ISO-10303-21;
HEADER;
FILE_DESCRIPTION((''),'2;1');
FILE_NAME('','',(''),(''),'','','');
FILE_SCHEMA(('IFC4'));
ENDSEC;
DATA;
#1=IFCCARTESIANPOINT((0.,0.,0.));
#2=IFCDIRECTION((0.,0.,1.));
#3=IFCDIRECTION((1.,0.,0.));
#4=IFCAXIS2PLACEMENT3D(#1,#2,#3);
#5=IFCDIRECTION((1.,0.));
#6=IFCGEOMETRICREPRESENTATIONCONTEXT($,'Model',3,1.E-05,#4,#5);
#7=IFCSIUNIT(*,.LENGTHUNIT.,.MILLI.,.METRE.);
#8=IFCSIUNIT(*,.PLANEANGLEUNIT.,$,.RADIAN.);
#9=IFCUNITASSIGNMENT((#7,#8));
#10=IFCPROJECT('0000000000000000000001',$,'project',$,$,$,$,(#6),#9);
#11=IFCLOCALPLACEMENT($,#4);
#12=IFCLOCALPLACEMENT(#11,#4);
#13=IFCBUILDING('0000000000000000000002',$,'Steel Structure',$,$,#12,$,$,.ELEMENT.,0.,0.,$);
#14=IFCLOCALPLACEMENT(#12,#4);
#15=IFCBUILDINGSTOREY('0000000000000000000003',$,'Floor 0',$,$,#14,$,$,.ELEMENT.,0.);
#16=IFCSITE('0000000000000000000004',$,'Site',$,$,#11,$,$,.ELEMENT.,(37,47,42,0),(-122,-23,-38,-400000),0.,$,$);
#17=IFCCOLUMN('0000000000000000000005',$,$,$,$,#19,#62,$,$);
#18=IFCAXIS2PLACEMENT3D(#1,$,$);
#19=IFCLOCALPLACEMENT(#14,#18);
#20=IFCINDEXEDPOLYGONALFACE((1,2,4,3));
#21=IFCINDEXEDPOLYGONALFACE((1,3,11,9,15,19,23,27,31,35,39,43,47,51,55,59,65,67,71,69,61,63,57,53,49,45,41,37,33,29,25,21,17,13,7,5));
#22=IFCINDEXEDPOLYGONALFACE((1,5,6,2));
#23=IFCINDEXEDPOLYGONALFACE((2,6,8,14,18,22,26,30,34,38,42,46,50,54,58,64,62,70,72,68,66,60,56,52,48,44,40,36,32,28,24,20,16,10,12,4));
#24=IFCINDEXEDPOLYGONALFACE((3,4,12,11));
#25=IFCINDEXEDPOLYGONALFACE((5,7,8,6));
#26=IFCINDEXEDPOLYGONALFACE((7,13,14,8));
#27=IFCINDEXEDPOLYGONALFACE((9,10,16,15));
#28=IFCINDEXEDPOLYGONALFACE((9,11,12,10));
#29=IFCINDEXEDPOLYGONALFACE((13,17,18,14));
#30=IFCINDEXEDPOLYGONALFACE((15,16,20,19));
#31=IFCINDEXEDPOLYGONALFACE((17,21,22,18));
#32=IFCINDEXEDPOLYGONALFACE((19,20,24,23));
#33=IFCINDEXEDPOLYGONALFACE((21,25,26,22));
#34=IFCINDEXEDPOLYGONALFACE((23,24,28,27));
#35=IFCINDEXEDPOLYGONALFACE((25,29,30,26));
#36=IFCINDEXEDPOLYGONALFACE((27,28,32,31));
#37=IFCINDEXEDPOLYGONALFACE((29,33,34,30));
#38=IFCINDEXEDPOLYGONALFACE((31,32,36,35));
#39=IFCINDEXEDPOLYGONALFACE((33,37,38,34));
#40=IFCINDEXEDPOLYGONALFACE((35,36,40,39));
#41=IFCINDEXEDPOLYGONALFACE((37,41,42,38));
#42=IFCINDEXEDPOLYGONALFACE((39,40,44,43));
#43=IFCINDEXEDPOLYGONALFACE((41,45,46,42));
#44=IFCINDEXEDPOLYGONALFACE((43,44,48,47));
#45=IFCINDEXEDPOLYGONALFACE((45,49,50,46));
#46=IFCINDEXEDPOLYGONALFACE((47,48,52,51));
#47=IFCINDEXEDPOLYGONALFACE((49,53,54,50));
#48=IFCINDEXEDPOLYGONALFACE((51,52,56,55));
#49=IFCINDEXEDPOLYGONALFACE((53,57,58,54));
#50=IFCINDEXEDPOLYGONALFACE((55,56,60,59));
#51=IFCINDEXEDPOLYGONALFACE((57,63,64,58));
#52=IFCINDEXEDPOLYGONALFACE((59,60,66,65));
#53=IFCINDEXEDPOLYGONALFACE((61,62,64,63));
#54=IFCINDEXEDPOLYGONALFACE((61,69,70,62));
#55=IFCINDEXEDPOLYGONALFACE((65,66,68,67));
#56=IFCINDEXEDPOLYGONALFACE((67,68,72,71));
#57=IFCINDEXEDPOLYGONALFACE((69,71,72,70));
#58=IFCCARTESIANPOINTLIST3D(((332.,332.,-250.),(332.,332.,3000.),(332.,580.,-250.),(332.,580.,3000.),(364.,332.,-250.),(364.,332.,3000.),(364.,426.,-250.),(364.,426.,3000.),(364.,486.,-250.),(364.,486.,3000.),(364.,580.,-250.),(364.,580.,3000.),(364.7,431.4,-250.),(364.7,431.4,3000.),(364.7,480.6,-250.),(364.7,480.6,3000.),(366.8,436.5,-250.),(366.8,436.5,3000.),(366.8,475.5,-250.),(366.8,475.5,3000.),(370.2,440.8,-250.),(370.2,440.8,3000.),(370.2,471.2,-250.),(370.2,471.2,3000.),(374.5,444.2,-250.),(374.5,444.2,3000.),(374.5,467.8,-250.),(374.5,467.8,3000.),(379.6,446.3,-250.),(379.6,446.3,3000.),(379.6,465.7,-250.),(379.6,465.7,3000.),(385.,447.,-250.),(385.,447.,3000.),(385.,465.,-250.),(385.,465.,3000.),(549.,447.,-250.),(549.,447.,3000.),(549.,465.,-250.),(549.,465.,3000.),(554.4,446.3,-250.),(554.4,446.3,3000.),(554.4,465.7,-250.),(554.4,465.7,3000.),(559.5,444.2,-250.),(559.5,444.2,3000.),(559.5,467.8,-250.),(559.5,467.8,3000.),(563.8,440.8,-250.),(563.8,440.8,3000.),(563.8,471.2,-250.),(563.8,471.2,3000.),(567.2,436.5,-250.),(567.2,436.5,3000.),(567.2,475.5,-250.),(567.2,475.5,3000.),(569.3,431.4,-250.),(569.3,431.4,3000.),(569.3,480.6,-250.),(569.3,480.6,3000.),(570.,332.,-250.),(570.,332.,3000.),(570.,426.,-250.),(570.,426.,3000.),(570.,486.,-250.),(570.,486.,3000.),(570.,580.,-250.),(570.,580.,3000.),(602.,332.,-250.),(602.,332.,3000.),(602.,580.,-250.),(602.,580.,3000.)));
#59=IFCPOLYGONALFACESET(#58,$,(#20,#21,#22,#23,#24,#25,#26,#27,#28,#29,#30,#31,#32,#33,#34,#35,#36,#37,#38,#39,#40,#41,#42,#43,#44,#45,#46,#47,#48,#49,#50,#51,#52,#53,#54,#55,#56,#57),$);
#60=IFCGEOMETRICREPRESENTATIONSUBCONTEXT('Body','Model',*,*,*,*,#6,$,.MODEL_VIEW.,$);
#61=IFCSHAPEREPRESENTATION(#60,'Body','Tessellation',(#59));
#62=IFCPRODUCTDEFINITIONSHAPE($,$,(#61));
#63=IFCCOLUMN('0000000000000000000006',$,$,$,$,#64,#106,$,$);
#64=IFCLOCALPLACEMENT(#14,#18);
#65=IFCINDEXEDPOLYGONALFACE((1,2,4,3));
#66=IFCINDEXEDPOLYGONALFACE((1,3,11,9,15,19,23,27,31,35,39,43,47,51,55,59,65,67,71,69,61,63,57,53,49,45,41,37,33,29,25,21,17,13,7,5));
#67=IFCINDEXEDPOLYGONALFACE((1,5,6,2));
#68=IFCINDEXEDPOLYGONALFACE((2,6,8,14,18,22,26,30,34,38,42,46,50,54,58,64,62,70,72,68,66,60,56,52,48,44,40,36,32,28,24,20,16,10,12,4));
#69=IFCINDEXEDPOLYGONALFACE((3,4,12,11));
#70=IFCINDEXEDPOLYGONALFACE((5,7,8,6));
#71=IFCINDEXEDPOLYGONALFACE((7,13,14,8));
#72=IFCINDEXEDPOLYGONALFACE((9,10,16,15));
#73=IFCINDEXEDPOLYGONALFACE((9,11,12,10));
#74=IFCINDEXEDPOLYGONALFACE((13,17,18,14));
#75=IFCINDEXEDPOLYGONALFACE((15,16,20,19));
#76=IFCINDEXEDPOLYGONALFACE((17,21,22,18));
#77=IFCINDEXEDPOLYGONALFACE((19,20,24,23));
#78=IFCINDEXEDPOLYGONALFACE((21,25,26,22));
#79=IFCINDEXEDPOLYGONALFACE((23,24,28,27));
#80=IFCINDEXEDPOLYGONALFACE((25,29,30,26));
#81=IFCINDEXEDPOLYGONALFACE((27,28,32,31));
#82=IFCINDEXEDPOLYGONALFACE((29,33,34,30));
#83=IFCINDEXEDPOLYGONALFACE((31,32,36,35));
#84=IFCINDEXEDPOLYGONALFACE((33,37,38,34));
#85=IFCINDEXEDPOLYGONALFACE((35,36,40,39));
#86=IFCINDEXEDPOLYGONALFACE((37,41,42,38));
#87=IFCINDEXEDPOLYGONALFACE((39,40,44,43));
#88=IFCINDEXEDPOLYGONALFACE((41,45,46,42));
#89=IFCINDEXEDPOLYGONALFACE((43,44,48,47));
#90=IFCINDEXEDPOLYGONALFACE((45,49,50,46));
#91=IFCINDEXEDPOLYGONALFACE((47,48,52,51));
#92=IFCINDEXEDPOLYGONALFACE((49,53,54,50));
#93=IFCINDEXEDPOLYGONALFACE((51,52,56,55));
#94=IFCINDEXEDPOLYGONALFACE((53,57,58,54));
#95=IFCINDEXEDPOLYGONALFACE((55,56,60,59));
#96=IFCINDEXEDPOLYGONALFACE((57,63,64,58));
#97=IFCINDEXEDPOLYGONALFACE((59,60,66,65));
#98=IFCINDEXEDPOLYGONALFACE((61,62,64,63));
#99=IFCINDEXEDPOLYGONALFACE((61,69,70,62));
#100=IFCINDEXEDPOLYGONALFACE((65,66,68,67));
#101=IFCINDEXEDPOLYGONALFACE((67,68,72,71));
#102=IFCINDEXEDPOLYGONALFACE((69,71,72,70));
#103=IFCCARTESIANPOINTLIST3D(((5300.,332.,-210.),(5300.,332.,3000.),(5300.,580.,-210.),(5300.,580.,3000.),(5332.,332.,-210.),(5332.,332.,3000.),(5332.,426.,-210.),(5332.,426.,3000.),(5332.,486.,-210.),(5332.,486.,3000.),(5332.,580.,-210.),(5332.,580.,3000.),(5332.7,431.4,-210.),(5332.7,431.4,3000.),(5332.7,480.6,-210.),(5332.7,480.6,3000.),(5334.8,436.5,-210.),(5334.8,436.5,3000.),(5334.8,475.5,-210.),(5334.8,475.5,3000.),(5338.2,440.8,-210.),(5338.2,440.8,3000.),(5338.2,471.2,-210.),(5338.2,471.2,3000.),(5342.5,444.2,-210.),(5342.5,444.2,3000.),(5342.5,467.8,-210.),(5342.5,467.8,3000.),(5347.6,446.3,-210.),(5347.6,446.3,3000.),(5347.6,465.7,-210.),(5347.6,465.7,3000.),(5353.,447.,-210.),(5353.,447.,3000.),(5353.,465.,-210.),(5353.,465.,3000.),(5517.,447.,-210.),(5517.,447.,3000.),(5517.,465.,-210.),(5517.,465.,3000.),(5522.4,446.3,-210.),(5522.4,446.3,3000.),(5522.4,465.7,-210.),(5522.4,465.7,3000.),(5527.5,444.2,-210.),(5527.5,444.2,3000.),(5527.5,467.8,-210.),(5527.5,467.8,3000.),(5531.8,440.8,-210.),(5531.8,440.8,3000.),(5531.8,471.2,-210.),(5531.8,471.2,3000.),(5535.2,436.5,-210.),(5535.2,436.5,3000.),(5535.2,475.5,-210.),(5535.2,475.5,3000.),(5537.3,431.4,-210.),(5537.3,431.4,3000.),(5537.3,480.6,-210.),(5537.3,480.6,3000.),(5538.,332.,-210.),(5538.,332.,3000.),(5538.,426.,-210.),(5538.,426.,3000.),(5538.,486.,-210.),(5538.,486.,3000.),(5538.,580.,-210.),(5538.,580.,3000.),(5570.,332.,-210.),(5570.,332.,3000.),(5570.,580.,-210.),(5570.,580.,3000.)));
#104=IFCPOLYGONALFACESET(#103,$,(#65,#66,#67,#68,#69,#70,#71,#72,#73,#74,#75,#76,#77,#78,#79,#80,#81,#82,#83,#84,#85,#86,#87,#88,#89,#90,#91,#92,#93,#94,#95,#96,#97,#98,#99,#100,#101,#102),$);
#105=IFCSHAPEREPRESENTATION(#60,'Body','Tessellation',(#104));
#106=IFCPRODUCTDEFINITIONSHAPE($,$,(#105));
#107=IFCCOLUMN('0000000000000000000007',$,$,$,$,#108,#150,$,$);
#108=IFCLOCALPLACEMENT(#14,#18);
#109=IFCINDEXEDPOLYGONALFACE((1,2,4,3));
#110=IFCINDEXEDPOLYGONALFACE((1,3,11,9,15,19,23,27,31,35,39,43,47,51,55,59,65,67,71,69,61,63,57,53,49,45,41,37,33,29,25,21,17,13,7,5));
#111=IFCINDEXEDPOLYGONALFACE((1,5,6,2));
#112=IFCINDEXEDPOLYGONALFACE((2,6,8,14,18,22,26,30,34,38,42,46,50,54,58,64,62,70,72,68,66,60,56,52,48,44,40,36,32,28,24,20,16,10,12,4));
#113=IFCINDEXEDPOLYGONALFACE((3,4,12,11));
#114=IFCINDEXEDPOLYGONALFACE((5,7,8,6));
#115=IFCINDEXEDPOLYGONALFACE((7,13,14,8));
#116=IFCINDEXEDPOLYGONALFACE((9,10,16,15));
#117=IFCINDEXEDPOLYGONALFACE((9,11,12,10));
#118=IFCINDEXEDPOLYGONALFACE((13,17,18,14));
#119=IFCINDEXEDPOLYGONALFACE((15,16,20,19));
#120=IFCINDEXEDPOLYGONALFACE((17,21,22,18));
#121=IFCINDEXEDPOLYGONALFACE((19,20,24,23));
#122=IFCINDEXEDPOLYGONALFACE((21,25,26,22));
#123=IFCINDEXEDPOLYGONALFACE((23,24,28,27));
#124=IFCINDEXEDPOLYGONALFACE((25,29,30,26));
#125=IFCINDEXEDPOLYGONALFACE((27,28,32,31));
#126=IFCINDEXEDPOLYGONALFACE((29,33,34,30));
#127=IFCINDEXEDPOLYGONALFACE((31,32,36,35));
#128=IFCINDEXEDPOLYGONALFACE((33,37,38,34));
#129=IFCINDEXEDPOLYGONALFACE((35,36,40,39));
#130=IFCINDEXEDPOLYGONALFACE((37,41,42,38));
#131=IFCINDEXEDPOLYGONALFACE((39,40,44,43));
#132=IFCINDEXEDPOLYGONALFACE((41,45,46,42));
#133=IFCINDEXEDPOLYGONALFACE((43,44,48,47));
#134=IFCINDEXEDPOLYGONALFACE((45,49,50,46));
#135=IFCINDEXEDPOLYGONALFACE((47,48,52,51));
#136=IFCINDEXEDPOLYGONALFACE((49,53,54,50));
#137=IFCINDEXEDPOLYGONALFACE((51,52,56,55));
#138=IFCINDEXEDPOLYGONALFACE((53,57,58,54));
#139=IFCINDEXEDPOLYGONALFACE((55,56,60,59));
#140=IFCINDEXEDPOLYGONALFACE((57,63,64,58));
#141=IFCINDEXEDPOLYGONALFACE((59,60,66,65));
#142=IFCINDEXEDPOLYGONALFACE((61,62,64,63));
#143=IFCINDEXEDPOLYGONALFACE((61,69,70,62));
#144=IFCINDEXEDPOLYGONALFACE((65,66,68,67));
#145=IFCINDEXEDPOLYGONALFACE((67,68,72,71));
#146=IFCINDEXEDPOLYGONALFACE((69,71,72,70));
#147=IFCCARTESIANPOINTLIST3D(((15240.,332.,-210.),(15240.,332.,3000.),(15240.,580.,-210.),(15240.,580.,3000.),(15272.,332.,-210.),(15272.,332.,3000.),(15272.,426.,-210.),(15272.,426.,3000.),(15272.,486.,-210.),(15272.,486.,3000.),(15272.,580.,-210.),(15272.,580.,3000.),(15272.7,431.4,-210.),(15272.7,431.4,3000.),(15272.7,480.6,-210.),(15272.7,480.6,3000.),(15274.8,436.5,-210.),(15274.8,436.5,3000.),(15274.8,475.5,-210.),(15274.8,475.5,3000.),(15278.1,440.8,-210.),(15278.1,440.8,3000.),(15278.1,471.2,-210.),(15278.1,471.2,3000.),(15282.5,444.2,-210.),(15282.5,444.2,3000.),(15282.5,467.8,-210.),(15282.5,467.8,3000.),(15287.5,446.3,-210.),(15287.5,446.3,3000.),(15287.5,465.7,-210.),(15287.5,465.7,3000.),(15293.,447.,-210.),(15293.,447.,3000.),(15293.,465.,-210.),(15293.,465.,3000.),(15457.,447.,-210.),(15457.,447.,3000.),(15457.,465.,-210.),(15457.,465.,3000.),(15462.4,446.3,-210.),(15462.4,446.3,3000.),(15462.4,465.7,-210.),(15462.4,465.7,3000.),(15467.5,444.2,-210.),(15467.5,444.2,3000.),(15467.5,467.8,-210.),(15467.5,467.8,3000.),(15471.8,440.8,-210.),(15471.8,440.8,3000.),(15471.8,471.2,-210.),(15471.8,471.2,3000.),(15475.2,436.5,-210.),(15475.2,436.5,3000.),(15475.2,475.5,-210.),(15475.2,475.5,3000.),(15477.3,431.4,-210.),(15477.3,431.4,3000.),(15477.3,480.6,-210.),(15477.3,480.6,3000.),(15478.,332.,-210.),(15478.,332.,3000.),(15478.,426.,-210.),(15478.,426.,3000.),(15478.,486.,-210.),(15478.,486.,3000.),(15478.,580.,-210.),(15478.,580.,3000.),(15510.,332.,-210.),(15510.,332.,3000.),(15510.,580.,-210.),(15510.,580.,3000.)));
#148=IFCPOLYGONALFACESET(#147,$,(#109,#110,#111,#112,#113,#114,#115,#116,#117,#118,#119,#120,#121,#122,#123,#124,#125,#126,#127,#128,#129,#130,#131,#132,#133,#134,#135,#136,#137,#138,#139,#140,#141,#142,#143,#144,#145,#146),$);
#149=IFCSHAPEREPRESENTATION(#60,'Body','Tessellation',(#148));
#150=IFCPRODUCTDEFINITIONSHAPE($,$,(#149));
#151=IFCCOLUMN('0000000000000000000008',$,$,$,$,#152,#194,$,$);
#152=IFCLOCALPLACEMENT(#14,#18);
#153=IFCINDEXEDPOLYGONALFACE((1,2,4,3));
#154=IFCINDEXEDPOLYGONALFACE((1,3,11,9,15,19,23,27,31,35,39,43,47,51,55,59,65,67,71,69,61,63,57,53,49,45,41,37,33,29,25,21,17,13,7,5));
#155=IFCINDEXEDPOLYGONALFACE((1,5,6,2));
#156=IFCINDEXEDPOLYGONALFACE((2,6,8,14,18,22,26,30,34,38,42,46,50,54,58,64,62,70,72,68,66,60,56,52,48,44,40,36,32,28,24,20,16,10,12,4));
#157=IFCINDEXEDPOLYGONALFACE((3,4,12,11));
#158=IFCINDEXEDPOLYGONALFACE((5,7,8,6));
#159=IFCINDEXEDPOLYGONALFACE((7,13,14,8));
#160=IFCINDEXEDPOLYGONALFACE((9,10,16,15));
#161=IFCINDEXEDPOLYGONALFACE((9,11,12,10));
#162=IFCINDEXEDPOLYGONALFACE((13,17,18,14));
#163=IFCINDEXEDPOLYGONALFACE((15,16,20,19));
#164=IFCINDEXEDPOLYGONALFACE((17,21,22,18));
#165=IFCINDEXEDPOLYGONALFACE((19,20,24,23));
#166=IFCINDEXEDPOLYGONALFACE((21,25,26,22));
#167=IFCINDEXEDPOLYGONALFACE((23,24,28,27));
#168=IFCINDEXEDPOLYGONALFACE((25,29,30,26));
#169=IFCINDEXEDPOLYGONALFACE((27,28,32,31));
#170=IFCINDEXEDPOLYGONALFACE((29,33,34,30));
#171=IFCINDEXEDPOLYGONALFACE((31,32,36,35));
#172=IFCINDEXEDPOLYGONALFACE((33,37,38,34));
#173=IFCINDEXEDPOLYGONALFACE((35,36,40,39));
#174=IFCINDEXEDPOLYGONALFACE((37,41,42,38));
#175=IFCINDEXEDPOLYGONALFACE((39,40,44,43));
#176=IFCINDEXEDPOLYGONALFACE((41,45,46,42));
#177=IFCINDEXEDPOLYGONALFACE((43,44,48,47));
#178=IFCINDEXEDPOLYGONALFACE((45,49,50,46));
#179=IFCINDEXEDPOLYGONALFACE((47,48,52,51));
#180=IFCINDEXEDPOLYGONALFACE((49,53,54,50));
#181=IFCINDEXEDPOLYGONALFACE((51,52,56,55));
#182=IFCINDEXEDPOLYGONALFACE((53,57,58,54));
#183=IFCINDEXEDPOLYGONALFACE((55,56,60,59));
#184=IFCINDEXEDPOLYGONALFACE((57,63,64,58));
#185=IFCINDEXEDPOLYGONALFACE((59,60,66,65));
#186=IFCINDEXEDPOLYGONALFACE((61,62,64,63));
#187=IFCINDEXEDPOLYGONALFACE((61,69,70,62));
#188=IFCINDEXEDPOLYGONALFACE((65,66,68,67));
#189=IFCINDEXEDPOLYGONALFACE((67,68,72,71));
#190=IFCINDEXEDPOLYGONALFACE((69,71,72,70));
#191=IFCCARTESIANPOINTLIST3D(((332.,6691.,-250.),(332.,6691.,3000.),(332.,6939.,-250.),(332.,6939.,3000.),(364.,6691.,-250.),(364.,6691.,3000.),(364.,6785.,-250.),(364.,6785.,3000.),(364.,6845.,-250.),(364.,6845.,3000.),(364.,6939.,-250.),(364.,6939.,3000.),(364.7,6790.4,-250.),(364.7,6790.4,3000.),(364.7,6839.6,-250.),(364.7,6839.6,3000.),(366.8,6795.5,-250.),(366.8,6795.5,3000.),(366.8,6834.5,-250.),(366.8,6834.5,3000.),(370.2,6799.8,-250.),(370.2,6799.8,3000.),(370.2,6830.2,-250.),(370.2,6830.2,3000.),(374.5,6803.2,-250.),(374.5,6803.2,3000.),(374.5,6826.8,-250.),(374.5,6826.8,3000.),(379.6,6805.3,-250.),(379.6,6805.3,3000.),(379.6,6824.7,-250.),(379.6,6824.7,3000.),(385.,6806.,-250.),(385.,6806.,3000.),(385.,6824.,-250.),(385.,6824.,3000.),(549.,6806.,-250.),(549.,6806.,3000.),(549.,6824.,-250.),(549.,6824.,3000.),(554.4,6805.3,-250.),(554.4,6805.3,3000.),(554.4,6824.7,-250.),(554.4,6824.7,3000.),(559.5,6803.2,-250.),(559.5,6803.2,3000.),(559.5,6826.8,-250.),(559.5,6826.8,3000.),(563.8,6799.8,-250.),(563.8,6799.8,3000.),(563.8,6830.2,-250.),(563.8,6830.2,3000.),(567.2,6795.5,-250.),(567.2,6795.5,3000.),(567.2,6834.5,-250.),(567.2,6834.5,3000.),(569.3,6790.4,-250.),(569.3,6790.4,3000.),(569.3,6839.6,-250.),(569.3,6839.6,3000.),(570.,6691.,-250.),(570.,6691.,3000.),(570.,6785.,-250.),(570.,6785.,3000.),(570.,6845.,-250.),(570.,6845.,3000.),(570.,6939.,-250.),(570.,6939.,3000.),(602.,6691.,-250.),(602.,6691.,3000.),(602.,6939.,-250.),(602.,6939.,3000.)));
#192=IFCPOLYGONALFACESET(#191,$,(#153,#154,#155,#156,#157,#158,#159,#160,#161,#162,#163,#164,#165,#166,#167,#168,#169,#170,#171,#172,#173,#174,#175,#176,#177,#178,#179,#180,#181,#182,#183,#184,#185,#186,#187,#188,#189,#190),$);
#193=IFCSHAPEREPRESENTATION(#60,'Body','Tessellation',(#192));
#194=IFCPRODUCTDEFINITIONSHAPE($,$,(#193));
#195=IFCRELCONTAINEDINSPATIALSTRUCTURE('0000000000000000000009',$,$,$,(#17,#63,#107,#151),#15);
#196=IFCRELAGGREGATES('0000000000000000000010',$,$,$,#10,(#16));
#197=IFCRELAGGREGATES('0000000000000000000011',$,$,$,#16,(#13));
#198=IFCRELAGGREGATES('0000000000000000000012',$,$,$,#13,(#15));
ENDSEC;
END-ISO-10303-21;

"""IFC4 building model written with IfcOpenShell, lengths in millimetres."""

from ifc_helpers import new_model, si_unit, direction, frame, origin_with_axes, origin_2d_with_axis, place, context, subcontext, project, spatial, i_section, extrude, element, save


model = new_model("IFC4")

# Units and contexts
model_context = context("Model", 3, precision=1e-05, world=origin_with_axes(), true_north=direction((1.0, 0.0)))
body_context = subcontext(model_context, "Body", "Model", "MODEL_VIEW")
ifc_project = project(units=[si_unit("LENGTHUNIT", "METRE", prefix="MILLI"), si_unit("PLANEANGLEUNIT", "RADIAN")], contexts=[model_context])

# Site, building, storey
site_placement = place(None, origin_with_axes())
site = spatial("IfcSite", under=ifc_project, at=site_placement, Name="Site", CompositionType="ELEMENT", RefLatitude=(37, 47, 42, 0), RefLongitude=(-122, -23, -38, -400000), RefElevation=0.0)
building_placement = place(site_placement, origin_with_axes())
building = spatial("IfcBuilding", under=site, at=building_placement, Name="Steel Structure", CompositionType="ELEMENT", ElevationOfRefHeight=0.0, ElevationOfTerrain=0.0)
storey_placement = place(building_placement, origin_with_axes())
storey = spatial("IfcBuildingStorey", under=building, at=storey_placement, Name="Floor 0", CompositionType="ELEMENT", Elevation=0.0)

# Columns
column_1_placement = place(storey_placement, frame((467.0, 456.0, -250.0), z_axis=(0.0, 0.0, 1.0), x_axis=(0.0, 1.0, 0.0)))
element("IfcColumn", 1, at=column_1_placement, inside=storey, context=body_context, shape_type="SweptSolid", body=[
    extrude(i_section(OverallWidth=248.0, OverallDepth=270.0, WebThickness=18.0, FlangeThickness=32.0, FilletRadius=21.0, at=origin_2d_with_axis()), origin_with_axes(), (0.0, 0.0, 1.0), 3250.0),
])
for number, where, z_axis, x_axis in (
    (2, (5435.0, 456.0, -210.0), (0.0, 0.0, 1.0), (0.0, 1.0, 0.0)),
    (3, (15375.0, 456.0, -210.0), (0.0, 0.0, 1.0), (0.0, 1.0, 0.0)),
):
    element("IfcColumn", number, at=place(storey_placement, frame(where, z_axis=z_axis, x_axis=x_axis)), inside=storey, context=body_context, shape_type="SweptSolid", body=[
        extrude(i_section(OverallWidth=248.0, OverallDepth=270.0, WebThickness=18.0, FlangeThickness=32.0, FilletRadius=21.0, at=origin_2d_with_axis()), origin_with_axes(), (0.0, 0.0, 1.0), 3210.0),
    ])
column_2_placement = place(storey_placement, frame((467.0, 6815.0, -250.0), z_axis=(0.0, 0.0, 1.0), x_axis=(0.0, -1.0, 0.0)))
element("IfcColumn", 4, at=column_2_placement, inside=storey, context=body_context, shape_type="SweptSolid", body=[
    extrude(i_section(OverallWidth=248.0, OverallDepth=270.0, WebThickness=18.0, FlangeThickness=32.0, FilletRadius=21.0, at=origin_2d_with_axis()), origin_with_axes(), (0.0, 0.0, 1.0), 3250.0),
])

save(model, "model.ifc")
